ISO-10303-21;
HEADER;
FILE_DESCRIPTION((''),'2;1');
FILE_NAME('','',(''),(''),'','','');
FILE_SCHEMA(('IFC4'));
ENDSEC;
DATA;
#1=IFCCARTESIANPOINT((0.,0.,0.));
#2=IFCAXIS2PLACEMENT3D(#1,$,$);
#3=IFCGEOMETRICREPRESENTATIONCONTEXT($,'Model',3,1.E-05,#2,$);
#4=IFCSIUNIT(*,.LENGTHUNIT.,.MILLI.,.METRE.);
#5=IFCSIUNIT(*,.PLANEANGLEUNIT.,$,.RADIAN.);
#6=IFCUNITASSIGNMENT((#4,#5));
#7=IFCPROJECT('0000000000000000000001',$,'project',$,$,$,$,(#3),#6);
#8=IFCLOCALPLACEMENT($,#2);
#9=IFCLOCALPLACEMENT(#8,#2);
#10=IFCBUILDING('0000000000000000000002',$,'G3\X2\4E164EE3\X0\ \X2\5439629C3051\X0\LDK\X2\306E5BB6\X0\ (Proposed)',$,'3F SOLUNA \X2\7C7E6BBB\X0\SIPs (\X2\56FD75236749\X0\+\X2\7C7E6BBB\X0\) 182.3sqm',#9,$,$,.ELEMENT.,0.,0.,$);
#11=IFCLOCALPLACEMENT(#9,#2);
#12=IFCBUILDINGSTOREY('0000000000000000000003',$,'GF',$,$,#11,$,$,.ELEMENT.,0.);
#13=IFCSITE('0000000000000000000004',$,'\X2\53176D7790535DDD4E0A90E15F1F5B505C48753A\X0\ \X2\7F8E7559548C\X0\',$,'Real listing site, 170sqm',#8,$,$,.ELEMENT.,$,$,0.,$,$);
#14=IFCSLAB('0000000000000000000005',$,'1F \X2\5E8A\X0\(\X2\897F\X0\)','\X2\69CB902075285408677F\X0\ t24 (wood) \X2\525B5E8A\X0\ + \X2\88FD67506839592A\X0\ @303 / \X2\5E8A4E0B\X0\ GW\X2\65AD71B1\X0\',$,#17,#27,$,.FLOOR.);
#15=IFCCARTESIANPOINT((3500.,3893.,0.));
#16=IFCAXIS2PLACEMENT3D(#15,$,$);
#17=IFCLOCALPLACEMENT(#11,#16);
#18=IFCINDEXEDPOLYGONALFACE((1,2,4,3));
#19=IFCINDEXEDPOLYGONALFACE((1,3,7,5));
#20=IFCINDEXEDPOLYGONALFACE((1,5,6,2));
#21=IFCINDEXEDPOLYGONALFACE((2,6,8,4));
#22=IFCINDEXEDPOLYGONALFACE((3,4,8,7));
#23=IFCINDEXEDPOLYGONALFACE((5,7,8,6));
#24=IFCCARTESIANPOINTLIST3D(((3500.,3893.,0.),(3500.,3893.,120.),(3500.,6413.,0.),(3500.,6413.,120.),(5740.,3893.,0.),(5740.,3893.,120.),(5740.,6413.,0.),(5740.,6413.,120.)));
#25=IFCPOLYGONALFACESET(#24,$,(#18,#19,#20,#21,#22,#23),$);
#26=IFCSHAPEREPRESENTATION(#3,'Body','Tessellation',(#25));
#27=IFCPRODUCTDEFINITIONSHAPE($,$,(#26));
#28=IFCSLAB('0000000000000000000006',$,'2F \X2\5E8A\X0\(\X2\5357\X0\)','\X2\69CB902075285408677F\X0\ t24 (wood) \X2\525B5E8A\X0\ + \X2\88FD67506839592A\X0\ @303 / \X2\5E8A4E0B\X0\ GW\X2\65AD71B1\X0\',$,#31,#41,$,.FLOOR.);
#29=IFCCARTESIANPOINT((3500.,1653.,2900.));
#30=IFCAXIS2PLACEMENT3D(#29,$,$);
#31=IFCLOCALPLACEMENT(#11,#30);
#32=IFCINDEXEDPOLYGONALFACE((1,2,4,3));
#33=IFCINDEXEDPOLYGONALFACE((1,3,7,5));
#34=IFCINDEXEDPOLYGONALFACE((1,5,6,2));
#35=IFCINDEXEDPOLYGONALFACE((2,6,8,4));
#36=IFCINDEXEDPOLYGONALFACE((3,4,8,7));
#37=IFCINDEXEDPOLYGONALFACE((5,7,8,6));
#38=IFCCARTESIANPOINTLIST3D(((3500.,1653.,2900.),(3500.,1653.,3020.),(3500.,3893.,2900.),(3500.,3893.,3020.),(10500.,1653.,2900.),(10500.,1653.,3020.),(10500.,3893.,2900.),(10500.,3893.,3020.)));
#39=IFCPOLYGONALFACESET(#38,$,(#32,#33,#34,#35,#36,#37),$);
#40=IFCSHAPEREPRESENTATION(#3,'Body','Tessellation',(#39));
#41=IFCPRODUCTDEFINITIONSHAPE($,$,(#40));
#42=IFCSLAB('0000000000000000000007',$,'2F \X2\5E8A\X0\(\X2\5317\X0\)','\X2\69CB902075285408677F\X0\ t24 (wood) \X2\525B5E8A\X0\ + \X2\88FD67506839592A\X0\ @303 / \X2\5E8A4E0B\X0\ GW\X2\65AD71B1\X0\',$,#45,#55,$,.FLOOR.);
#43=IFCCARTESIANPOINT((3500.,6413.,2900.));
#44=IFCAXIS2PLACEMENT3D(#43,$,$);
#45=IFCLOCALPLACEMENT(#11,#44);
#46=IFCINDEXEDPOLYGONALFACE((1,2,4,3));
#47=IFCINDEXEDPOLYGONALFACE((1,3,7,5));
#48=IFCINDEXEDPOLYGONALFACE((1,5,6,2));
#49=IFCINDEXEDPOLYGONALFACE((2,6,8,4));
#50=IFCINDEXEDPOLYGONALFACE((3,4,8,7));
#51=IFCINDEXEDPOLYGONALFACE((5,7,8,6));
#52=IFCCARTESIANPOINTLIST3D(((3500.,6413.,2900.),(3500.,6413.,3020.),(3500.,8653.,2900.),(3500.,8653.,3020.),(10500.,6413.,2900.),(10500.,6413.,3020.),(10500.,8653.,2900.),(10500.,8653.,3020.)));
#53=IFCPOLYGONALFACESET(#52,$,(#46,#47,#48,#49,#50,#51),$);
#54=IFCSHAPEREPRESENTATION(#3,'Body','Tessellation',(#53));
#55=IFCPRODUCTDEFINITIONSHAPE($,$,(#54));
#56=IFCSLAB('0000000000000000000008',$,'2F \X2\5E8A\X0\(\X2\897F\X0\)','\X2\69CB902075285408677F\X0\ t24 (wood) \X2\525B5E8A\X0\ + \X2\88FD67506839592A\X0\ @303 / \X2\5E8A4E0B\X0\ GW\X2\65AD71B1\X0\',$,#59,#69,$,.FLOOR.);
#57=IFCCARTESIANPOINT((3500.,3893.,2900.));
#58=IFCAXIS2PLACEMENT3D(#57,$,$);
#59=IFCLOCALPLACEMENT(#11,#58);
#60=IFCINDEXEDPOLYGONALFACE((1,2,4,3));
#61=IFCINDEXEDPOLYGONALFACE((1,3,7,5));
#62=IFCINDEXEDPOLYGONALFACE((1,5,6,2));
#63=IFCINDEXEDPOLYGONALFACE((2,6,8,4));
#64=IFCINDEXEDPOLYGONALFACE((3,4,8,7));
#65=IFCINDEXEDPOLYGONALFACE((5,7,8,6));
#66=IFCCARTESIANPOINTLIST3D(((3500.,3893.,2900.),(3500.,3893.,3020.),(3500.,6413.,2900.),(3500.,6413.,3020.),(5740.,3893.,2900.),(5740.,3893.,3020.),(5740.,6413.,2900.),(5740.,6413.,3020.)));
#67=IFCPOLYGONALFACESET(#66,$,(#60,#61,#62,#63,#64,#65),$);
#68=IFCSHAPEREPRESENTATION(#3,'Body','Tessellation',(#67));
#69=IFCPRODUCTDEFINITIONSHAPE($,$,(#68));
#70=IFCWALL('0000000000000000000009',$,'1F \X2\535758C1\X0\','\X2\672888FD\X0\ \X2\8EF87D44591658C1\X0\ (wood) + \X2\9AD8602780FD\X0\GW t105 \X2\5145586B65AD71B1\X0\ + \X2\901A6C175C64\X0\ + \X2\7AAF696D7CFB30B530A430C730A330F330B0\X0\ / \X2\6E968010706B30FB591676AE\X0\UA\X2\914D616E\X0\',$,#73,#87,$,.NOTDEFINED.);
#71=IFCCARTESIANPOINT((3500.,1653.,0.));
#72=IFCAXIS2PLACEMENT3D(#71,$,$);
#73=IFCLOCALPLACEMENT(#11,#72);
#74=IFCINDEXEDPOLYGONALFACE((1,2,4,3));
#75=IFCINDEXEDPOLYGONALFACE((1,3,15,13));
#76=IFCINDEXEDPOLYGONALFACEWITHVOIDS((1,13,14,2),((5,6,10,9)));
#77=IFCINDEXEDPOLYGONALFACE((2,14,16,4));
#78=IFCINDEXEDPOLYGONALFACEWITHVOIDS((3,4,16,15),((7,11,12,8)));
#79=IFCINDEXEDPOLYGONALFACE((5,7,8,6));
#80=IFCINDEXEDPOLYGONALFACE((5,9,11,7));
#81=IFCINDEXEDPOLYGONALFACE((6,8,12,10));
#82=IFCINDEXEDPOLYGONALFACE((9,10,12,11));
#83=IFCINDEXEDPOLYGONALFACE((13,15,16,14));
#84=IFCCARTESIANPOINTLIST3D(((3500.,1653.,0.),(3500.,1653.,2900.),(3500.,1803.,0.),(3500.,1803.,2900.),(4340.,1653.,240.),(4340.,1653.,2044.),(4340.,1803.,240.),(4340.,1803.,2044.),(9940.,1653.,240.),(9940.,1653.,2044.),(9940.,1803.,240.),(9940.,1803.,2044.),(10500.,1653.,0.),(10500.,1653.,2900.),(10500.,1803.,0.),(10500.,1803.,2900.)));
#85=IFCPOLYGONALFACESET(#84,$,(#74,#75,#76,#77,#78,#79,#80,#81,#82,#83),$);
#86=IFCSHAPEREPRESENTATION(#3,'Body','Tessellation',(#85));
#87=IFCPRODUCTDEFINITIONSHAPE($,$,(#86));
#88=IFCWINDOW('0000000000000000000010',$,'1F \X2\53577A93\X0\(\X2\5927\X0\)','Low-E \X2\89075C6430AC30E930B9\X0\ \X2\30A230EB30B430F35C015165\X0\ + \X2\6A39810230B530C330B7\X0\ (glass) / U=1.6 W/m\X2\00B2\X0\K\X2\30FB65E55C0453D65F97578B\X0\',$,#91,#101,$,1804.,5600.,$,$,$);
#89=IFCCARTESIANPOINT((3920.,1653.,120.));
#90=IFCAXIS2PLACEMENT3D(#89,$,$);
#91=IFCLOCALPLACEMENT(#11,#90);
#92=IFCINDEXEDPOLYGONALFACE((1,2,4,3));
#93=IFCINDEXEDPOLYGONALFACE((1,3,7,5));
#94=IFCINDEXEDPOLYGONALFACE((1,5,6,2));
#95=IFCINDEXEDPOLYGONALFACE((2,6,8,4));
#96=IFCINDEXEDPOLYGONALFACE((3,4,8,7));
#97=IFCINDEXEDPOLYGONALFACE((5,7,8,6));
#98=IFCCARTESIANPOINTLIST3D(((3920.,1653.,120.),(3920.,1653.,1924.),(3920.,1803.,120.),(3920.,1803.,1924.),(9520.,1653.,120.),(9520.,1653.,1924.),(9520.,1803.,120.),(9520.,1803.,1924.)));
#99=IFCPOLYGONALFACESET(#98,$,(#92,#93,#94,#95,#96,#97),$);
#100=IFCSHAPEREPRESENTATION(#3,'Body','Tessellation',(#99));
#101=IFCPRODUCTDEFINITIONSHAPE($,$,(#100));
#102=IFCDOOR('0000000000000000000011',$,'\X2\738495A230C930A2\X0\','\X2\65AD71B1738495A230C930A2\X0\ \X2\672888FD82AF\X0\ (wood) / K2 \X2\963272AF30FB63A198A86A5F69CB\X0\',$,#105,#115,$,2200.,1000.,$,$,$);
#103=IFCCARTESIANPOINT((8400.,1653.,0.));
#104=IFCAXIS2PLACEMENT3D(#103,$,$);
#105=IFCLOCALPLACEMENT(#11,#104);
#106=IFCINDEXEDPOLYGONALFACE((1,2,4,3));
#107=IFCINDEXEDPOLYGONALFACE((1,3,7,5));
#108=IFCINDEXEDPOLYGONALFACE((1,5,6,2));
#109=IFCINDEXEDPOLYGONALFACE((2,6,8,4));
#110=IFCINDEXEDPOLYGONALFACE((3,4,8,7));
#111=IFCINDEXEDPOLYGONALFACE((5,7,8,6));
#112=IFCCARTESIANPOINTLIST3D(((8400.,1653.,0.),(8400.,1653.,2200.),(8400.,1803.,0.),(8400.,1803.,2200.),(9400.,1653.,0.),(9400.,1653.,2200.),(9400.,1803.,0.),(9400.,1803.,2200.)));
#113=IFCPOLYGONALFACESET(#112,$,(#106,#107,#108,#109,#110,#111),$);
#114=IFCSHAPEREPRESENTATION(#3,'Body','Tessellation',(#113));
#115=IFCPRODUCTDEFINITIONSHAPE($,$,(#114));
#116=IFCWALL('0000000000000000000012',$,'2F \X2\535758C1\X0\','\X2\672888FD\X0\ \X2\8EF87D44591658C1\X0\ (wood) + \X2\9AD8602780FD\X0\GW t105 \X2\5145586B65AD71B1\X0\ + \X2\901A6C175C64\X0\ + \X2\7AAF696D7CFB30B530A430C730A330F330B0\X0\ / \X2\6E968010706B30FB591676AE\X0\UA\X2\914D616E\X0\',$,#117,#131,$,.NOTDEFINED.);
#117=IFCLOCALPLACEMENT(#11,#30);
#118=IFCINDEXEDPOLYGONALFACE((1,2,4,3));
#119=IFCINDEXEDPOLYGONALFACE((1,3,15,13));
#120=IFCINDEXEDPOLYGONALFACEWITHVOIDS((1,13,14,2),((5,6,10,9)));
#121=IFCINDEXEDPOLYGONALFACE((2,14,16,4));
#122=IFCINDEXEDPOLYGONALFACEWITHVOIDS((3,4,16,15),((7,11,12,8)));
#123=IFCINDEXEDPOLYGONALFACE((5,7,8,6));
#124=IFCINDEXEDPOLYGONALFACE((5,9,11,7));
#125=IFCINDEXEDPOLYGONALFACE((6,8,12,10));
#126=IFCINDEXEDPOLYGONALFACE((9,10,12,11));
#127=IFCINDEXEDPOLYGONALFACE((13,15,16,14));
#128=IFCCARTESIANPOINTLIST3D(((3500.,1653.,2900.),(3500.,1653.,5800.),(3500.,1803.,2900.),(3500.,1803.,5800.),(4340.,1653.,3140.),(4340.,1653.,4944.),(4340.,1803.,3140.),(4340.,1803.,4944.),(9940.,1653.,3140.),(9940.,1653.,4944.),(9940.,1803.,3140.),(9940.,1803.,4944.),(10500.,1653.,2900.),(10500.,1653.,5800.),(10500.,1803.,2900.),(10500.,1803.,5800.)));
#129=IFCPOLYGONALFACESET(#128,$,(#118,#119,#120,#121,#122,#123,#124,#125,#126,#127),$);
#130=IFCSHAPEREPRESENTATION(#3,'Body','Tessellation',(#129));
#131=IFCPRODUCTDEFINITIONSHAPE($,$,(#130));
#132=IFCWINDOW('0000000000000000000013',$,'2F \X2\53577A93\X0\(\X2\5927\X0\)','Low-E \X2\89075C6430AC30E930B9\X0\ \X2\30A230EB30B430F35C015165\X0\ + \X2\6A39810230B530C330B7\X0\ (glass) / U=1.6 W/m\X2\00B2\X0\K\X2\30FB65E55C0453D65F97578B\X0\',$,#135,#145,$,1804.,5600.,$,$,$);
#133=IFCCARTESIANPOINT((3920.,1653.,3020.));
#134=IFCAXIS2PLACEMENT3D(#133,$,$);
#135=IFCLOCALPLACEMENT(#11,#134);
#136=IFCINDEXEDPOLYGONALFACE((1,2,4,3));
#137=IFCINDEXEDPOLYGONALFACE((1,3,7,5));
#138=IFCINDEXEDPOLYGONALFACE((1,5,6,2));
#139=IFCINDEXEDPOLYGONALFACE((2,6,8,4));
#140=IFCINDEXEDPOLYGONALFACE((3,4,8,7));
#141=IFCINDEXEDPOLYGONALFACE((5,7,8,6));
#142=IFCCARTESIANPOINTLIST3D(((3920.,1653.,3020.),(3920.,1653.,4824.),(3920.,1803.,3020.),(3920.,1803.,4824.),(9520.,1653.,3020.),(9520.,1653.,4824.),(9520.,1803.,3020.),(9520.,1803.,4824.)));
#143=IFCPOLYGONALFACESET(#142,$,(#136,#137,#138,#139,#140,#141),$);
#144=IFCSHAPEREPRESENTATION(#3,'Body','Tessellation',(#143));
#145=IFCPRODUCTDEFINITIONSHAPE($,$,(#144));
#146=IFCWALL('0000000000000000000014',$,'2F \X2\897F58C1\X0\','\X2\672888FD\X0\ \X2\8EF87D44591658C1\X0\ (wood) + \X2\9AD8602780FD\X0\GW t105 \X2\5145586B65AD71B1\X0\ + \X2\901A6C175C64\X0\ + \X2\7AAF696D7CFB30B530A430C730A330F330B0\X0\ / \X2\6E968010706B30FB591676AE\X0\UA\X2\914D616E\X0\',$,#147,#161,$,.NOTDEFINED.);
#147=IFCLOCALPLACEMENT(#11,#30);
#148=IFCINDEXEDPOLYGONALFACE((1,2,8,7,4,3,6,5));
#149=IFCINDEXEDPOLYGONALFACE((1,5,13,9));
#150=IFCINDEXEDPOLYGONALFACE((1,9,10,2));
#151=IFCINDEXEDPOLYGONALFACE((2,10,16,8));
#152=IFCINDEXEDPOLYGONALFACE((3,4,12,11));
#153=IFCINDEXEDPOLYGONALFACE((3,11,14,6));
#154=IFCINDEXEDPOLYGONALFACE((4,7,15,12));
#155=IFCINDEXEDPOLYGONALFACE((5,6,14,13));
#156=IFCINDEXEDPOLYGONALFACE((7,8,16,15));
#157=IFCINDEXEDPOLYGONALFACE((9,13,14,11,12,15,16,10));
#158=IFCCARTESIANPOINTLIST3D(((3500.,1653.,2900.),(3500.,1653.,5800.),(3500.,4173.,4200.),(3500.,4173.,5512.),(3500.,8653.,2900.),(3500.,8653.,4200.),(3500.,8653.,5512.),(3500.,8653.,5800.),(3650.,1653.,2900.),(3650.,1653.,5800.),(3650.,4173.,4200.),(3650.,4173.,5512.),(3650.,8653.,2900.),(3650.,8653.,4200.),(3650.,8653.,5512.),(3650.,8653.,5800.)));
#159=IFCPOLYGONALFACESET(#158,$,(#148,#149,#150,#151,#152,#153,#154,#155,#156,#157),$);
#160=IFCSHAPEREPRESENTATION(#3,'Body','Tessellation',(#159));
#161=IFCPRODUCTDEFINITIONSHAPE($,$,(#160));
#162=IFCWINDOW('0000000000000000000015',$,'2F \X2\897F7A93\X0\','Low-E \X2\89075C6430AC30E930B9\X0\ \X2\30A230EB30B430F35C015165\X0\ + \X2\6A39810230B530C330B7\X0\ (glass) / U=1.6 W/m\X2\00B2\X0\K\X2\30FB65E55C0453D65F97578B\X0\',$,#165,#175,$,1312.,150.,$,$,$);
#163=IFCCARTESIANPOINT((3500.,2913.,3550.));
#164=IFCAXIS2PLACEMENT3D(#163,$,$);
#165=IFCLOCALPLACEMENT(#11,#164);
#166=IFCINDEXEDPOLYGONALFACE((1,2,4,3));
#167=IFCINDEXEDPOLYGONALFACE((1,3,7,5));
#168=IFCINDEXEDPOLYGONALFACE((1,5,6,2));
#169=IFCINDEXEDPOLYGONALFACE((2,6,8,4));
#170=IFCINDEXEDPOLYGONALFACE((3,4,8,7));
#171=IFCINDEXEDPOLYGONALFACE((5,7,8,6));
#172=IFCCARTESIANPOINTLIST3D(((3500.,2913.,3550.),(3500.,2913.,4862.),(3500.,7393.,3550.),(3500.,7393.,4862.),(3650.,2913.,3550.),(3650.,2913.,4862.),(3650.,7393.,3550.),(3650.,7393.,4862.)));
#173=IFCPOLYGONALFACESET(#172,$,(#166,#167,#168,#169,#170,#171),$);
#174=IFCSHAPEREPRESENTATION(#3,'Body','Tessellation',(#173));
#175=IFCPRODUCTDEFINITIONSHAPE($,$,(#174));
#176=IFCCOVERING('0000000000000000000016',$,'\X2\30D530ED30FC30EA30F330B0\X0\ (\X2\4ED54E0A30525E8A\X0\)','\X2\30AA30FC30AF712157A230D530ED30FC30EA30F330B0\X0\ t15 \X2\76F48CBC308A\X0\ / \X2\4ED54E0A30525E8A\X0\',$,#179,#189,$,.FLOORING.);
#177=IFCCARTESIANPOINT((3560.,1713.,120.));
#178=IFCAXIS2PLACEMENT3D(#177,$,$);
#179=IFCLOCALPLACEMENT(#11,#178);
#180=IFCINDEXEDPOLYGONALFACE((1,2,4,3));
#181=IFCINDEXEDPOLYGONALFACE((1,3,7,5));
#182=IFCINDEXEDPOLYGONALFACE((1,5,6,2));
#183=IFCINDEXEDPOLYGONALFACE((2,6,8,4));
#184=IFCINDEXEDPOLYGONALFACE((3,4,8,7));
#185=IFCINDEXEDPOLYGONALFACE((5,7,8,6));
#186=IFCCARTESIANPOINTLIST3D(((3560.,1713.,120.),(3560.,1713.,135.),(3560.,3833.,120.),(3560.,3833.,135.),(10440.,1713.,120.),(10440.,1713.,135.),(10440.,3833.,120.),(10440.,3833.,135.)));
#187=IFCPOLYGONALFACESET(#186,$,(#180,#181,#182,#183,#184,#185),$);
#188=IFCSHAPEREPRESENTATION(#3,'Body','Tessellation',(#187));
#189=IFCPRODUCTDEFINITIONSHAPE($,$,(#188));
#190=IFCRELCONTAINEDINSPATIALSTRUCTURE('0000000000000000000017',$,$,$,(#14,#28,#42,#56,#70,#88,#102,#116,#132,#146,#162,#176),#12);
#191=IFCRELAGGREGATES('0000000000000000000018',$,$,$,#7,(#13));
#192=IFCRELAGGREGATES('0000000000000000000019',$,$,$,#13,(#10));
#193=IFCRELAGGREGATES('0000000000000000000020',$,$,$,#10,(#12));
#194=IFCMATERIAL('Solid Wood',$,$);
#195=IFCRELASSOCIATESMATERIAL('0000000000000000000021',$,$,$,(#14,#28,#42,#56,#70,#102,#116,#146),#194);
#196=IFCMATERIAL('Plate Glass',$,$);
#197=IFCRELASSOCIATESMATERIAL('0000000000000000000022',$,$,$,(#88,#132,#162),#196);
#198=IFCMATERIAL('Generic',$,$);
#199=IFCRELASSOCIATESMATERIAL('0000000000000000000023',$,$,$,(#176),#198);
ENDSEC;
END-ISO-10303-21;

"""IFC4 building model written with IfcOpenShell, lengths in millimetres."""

from ifc_helpers import new_model, si_unit, frame, frame_2d, origin, place, context, project, spatial, rectangle, extrude, material, element, fill, save


model = new_model("IFC4")

# Units and contexts
model_context = context("Model", 3, precision=1e-05, world=origin())
ifc_project = project(units=[si_unit("LENGTHUNIT", "METRE", prefix="MILLI"), si_unit("PLANEANGLEUNIT", "RADIAN")], contexts=[model_context])

# Site, building, storey
site_placement = place(None, origin())
site = spatial("IfcSite", under=ifc_project, at=site_placement, Name="北海道川上郡弟子屈町 美留和", ObjectType="Real listing site, 170sqm", CompositionType="ELEMENT", RefElevation=0.0)
building_placement = place(site_placement, origin())
building = spatial("IfcBuilding", under=site, at=building_placement, Name="G3世代 吹抜けLDKの家 (Proposed)", ObjectType="3F SOLUNA 籾殻SIPs (国産杉+籾殻) 182.3sqm", CompositionType="ELEMENT", ElevationOfRefHeight=0.0, ElevationOfTerrain=0.0)
storey_placement = place(building_placement, origin())
storey = spatial("IfcBuildingStorey", under=building, at=storey_placement, Name="GF", CompositionType="ELEMENT", Elevation=0.0)

# Slabs
ifc_material_1 = material(Name="Solid Wood")
slab_1_placement = place(storey_placement, frame((3500.0, 3893.0, 0.0)))
element("IfcSlab", 1, at=slab_1_placement, inside=storey, material=ifc_material_1, Name="1F 床(西)", Description="構造用合板 t24 (wood) 剛床 + 製材根太 @303 / 床下 GW断熱", PredefinedType="FLOOR", context=model_context, shape_type="SweptSolid", body=[
    extrude(rectangle(XDim=2240.0, YDim=2520.0, at=frame_2d((1120.0, 1260.0))), frame((3500.0, 3893.0, 0.0)), (0.0, 0.0, 1.0), 120.0),
])
slab_2_placement = place(storey_placement, frame((3500.0, 1653.0, 2900.0)))
element("IfcSlab", 2, at=slab_2_placement, inside=storey, material=ifc_material_1, Name="2F 床(南)", Description="構造用合板 t24 (wood) 剛床 + 製材根太 @303 / 床下 GW断熱", PredefinedType="FLOOR", context=model_context, shape_type="SweptSolid", body=[
    extrude(rectangle(XDim=7000.0, YDim=2240.0, at=frame_2d((3500.0, 1120.0))), frame((3500.0, 1653.0, 2900.0)), (0.0, 0.0, 1.0), 120.0),
])
slab_3_placement = place(storey_placement, frame((3500.0, 6413.0, 2900.0)))
element("IfcSlab", 3, at=slab_3_placement, inside=storey, material=ifc_material_1, Name="2F 床(北)", Description="構造用合板 t24 (wood) 剛床 + 製材根太 @303 / 床下 GW断熱", PredefinedType="FLOOR", context=model_context, shape_type="SweptSolid", body=[
    extrude(rectangle(XDim=7000.0, YDim=2240.0, at=frame_2d((3500.0, 1120.0))), frame((3500.0, 6413.0, 2900.0)), (0.0, 0.0, 1.0), 120.0),
])
slab_4_placement = place(storey_placement, frame((3500.0, 3893.0, 2900.0)))
element("IfcSlab", 4, at=slab_4_placement, inside=storey, material=ifc_material_1, Name="2F 床(西)", Description="構造用合板 t24 (wood) 剛床 + 製材根太 @303 / 床下 GW断熱", PredefinedType="FLOOR", context=model_context, shape_type="SweptSolid", body=[
    extrude(rectangle(XDim=2240.0, YDim=2520.0, at=frame_2d((1120.0, 1260.0))), frame((3500.0, 3893.0, 2900.0)), (0.0, 0.0, 1.0), 120.0),
])

# Wall, openings, window, door
wall_1_placement = place(storey_placement, frame((3500.0, 1653.0, 0.0)))
wall_1 = element("IfcWall", 5, at=wall_1_placement, inside=storey, material=ifc_material_1, Name="1F 南壁", Description="木製 軸組外壁 (wood) + 高性能GW t105 充填断熱 + 通気層 + 窯業系サイディング / 準耐火・外皮UA配慮", PredefinedType="NOTDEFINED", context=model_context, shape_type="SweptSolid", body=[
    extrude(rectangle(XDim=7000.0, YDim=150.0, at=frame_2d((3500.0, 75.0))), frame((3500.0, 1653.0, 0.0)), (0.0, 0.0, 1.0), 2900.0),
])
opening_1_placement = place(storey_placement, frame((3920.0, 1653.0, 120.0)))
opening_1 = element("IfcOpeningElement", 6, at=opening_1_placement, cuts=wall_1, PredefinedType="NOTDEFINED", context=model_context, shape_type="SweptSolid", body=[
    extrude(rectangle(XDim=5600.0, YDim=150.0, at=frame_2d((2800.0, 75.0))), frame((3920.0, 1653.0, 120.0)), (0.0, 0.0, 1.0), 1804.0),
])
opening_2_placement = place(storey_placement, frame((8400.0, 1653.0, 0.0)))
opening_2 = element("IfcOpeningElement", 7, at=opening_2_placement, cuts=wall_1, PredefinedType="NOTDEFINED", context=model_context, shape_type="SweptSolid", body=[
    extrude(rectangle(XDim=1000.0, YDim=150.0, at=frame_2d((500.0, 75.0))), frame((8400.0, 1653.0, 0.0)), (0.0, 0.0, 1.0), 2200.0),
])
ifc_material_2 = material(Name="Plate Glass")
window_1_placement = place(storey_placement, frame((3920.0, 1653.0, 120.0)))
window_1 = element("IfcWindow", 8, at=window_1_placement, inside=storey, material=ifc_material_2, Name="1F 南窓(大)", Description="Low-E 複層ガラス アルゴン封入 + 樹脂サッシ (glass) / U=1.6 W/m²K・日射取得型", OverallHeight=1804.0, OverallWidth=5600.0, context=model_context, shape_type="SweptSolid", body=[
    extrude(rectangle(XDim=5600.0, YDim=150.0, at=frame_2d((2800.0, 75.0))), frame((3920.0, 1653.0, 120.0)), (0.0, 0.0, 1.0), 1804.0),
])
fill(opening_1, window_1)
door_placement = place(storey_placement, frame((8400.0, 1653.0, 0.0)))
door = element("IfcDoor", 9, at=door_placement, inside=storey, material=ifc_material_1, Name="玄関ドア", Description="断熱玄関ドア 木製芯 (wood) / K2 防犯・採風機構", OverallHeight=2200.0, OverallWidth=1000.0, context=model_context, shape_type="SweptSolid", body=[
    extrude(rectangle(XDim=1000.0, YDim=150.0, at=frame_2d((500.0, 75.0))), frame((8400.0, 1653.0, 0.0)), (0.0, 0.0, 1.0), 2200.0),
])
fill(opening_2, door)

# Wall, opening, window
wall_2_placement = place(storey_placement, frame((3500.0, 1653.0, 2900.0)))
wall_2 = element("IfcWall", 10, at=wall_2_placement, inside=storey, material=ifc_material_1, Name="2F 南壁", Description="木製 軸組外壁 (wood) + 高性能GW t105 充填断熱 + 通気層 + 窯業系サイディング / 準耐火・外皮UA配慮", PredefinedType="NOTDEFINED", context=model_context, shape_type="SweptSolid", body=[
    extrude(rectangle(XDim=7000.0, YDim=150.0, at=frame_2d((3500.0, 75.0))), frame((3500.0, 1653.0, 2900.0)), (0.0, 0.0, 1.0), 2900.0),
])
opening_3_placement = place(storey_placement, frame((3920.0, 1653.0, 3020.0)))
opening_3 = element("IfcOpeningElement", 11, at=opening_3_placement, cuts=wall_2, PredefinedType="NOTDEFINED", context=model_context, shape_type="SweptSolid", body=[
    extrude(rectangle(XDim=5600.0, YDim=150.0, at=frame_2d((2800.0, 75.0))), frame((3920.0, 1653.0, 3020.0)), (0.0, 0.0, 1.0), 1804.0),
])
window_2_placement = place(storey_placement, frame((3920.0, 1653.0, 3020.0)))
window_2 = element("IfcWindow", 12, at=window_2_placement, inside=storey, material=ifc_material_2, Name="2F 南窓(大)", Description="Low-E 複層ガラス アルゴン封入 + 樹脂サッシ (glass) / U=1.6 W/m²K・日射取得型", OverallHeight=1804.0, OverallWidth=5600.0, context=model_context, shape_type="SweptSolid", body=[
    extrude(rectangle(XDim=5600.0, YDim=150.0, at=frame_2d((2800.0, 75.0))), frame((3920.0, 1653.0, 3020.0)), (0.0, 0.0, 1.0), 1804.0),
])
fill(opening_3, window_2)

# Wall, opening, window
wall_3_placement = place(storey_placement, frame((3500.0, 1653.0, 2900.0)))
wall_3 = element("IfcWall", 13, at=wall_3_placement, inside=storey, material=ifc_material_1, Name="2F 西壁", Description="木製 軸組外壁 (wood) + 高性能GW t105 充填断熱 + 通気層 + 窯業系サイディング / 準耐火・外皮UA配慮", PredefinedType="NOTDEFINED", context=model_context, shape_type="SweptSolid", body=[
    extrude(rectangle(XDim=150.0, YDim=7000.0, at=frame_2d((75.0, 3500.0))), frame((3500.0, 1653.0, 2900.0)), (0.0, 0.0, 1.0), 2900.0),
])
opening_4_placement = place(storey_placement, frame((3500.0, 2913.0, 3550.0)))
opening_4 = element("IfcOpeningElement", 14, at=opening_4_placement, cuts=wall_3, PredefinedType="NOTDEFINED", context=model_context, shape_type="SweptSolid", body=[
    extrude(rectangle(XDim=150.0, YDim=4480.0, at=frame_2d((75.0, 2240.0))), frame((3500.0, 2913.0, 3550.0)), (0.0, 0.0, 1.0), 1312.0),
])
window_3_placement = place(storey_placement, frame((3500.0, 2913.0, 3550.0)))
window_3 = element("IfcWindow", 15, at=window_3_placement, inside=storey, material=ifc_material_2, Name="2F 西窓", Description="Low-E 複層ガラス アルゴン封入 + 樹脂サッシ (glass) / U=1.6 W/m²K・日射取得型", OverallHeight=1312.0, OverallWidth=150.0, context=model_context, shape_type="SweptSolid", body=[
    extrude(rectangle(XDim=150.0, YDim=4480.0, at=frame_2d((75.0, 2240.0))), frame((3500.0, 2913.0, 3550.0)), (0.0, 0.0, 1.0), 1312.0),
])
fill(opening_4, window_3)

# Covering
ifc_material_3 = material(Name="Generic")
covering_1_placement = place(storey_placement, frame((3560.0, 1713.0, 120.0)))
element("IfcCovering", 16, at=covering_1_placement, inside=storey, material=ifc_material_3, Name="フローリング (仕上げ床)", Description="オーク無垢フローリング t15 直貼り / 仕上げ床", PredefinedType="FLOORING", context=model_context, shape_type="SweptSolid", body=[
    extrude(rectangle(XDim=6880.0, YDim=2120.0, at=frame_2d((3440.0, 1060.0))), frame((3560.0, 1713.0, 120.0)), (0.0, 0.0, 1.0), 15.0),
])

save(model, "model.ifc")
